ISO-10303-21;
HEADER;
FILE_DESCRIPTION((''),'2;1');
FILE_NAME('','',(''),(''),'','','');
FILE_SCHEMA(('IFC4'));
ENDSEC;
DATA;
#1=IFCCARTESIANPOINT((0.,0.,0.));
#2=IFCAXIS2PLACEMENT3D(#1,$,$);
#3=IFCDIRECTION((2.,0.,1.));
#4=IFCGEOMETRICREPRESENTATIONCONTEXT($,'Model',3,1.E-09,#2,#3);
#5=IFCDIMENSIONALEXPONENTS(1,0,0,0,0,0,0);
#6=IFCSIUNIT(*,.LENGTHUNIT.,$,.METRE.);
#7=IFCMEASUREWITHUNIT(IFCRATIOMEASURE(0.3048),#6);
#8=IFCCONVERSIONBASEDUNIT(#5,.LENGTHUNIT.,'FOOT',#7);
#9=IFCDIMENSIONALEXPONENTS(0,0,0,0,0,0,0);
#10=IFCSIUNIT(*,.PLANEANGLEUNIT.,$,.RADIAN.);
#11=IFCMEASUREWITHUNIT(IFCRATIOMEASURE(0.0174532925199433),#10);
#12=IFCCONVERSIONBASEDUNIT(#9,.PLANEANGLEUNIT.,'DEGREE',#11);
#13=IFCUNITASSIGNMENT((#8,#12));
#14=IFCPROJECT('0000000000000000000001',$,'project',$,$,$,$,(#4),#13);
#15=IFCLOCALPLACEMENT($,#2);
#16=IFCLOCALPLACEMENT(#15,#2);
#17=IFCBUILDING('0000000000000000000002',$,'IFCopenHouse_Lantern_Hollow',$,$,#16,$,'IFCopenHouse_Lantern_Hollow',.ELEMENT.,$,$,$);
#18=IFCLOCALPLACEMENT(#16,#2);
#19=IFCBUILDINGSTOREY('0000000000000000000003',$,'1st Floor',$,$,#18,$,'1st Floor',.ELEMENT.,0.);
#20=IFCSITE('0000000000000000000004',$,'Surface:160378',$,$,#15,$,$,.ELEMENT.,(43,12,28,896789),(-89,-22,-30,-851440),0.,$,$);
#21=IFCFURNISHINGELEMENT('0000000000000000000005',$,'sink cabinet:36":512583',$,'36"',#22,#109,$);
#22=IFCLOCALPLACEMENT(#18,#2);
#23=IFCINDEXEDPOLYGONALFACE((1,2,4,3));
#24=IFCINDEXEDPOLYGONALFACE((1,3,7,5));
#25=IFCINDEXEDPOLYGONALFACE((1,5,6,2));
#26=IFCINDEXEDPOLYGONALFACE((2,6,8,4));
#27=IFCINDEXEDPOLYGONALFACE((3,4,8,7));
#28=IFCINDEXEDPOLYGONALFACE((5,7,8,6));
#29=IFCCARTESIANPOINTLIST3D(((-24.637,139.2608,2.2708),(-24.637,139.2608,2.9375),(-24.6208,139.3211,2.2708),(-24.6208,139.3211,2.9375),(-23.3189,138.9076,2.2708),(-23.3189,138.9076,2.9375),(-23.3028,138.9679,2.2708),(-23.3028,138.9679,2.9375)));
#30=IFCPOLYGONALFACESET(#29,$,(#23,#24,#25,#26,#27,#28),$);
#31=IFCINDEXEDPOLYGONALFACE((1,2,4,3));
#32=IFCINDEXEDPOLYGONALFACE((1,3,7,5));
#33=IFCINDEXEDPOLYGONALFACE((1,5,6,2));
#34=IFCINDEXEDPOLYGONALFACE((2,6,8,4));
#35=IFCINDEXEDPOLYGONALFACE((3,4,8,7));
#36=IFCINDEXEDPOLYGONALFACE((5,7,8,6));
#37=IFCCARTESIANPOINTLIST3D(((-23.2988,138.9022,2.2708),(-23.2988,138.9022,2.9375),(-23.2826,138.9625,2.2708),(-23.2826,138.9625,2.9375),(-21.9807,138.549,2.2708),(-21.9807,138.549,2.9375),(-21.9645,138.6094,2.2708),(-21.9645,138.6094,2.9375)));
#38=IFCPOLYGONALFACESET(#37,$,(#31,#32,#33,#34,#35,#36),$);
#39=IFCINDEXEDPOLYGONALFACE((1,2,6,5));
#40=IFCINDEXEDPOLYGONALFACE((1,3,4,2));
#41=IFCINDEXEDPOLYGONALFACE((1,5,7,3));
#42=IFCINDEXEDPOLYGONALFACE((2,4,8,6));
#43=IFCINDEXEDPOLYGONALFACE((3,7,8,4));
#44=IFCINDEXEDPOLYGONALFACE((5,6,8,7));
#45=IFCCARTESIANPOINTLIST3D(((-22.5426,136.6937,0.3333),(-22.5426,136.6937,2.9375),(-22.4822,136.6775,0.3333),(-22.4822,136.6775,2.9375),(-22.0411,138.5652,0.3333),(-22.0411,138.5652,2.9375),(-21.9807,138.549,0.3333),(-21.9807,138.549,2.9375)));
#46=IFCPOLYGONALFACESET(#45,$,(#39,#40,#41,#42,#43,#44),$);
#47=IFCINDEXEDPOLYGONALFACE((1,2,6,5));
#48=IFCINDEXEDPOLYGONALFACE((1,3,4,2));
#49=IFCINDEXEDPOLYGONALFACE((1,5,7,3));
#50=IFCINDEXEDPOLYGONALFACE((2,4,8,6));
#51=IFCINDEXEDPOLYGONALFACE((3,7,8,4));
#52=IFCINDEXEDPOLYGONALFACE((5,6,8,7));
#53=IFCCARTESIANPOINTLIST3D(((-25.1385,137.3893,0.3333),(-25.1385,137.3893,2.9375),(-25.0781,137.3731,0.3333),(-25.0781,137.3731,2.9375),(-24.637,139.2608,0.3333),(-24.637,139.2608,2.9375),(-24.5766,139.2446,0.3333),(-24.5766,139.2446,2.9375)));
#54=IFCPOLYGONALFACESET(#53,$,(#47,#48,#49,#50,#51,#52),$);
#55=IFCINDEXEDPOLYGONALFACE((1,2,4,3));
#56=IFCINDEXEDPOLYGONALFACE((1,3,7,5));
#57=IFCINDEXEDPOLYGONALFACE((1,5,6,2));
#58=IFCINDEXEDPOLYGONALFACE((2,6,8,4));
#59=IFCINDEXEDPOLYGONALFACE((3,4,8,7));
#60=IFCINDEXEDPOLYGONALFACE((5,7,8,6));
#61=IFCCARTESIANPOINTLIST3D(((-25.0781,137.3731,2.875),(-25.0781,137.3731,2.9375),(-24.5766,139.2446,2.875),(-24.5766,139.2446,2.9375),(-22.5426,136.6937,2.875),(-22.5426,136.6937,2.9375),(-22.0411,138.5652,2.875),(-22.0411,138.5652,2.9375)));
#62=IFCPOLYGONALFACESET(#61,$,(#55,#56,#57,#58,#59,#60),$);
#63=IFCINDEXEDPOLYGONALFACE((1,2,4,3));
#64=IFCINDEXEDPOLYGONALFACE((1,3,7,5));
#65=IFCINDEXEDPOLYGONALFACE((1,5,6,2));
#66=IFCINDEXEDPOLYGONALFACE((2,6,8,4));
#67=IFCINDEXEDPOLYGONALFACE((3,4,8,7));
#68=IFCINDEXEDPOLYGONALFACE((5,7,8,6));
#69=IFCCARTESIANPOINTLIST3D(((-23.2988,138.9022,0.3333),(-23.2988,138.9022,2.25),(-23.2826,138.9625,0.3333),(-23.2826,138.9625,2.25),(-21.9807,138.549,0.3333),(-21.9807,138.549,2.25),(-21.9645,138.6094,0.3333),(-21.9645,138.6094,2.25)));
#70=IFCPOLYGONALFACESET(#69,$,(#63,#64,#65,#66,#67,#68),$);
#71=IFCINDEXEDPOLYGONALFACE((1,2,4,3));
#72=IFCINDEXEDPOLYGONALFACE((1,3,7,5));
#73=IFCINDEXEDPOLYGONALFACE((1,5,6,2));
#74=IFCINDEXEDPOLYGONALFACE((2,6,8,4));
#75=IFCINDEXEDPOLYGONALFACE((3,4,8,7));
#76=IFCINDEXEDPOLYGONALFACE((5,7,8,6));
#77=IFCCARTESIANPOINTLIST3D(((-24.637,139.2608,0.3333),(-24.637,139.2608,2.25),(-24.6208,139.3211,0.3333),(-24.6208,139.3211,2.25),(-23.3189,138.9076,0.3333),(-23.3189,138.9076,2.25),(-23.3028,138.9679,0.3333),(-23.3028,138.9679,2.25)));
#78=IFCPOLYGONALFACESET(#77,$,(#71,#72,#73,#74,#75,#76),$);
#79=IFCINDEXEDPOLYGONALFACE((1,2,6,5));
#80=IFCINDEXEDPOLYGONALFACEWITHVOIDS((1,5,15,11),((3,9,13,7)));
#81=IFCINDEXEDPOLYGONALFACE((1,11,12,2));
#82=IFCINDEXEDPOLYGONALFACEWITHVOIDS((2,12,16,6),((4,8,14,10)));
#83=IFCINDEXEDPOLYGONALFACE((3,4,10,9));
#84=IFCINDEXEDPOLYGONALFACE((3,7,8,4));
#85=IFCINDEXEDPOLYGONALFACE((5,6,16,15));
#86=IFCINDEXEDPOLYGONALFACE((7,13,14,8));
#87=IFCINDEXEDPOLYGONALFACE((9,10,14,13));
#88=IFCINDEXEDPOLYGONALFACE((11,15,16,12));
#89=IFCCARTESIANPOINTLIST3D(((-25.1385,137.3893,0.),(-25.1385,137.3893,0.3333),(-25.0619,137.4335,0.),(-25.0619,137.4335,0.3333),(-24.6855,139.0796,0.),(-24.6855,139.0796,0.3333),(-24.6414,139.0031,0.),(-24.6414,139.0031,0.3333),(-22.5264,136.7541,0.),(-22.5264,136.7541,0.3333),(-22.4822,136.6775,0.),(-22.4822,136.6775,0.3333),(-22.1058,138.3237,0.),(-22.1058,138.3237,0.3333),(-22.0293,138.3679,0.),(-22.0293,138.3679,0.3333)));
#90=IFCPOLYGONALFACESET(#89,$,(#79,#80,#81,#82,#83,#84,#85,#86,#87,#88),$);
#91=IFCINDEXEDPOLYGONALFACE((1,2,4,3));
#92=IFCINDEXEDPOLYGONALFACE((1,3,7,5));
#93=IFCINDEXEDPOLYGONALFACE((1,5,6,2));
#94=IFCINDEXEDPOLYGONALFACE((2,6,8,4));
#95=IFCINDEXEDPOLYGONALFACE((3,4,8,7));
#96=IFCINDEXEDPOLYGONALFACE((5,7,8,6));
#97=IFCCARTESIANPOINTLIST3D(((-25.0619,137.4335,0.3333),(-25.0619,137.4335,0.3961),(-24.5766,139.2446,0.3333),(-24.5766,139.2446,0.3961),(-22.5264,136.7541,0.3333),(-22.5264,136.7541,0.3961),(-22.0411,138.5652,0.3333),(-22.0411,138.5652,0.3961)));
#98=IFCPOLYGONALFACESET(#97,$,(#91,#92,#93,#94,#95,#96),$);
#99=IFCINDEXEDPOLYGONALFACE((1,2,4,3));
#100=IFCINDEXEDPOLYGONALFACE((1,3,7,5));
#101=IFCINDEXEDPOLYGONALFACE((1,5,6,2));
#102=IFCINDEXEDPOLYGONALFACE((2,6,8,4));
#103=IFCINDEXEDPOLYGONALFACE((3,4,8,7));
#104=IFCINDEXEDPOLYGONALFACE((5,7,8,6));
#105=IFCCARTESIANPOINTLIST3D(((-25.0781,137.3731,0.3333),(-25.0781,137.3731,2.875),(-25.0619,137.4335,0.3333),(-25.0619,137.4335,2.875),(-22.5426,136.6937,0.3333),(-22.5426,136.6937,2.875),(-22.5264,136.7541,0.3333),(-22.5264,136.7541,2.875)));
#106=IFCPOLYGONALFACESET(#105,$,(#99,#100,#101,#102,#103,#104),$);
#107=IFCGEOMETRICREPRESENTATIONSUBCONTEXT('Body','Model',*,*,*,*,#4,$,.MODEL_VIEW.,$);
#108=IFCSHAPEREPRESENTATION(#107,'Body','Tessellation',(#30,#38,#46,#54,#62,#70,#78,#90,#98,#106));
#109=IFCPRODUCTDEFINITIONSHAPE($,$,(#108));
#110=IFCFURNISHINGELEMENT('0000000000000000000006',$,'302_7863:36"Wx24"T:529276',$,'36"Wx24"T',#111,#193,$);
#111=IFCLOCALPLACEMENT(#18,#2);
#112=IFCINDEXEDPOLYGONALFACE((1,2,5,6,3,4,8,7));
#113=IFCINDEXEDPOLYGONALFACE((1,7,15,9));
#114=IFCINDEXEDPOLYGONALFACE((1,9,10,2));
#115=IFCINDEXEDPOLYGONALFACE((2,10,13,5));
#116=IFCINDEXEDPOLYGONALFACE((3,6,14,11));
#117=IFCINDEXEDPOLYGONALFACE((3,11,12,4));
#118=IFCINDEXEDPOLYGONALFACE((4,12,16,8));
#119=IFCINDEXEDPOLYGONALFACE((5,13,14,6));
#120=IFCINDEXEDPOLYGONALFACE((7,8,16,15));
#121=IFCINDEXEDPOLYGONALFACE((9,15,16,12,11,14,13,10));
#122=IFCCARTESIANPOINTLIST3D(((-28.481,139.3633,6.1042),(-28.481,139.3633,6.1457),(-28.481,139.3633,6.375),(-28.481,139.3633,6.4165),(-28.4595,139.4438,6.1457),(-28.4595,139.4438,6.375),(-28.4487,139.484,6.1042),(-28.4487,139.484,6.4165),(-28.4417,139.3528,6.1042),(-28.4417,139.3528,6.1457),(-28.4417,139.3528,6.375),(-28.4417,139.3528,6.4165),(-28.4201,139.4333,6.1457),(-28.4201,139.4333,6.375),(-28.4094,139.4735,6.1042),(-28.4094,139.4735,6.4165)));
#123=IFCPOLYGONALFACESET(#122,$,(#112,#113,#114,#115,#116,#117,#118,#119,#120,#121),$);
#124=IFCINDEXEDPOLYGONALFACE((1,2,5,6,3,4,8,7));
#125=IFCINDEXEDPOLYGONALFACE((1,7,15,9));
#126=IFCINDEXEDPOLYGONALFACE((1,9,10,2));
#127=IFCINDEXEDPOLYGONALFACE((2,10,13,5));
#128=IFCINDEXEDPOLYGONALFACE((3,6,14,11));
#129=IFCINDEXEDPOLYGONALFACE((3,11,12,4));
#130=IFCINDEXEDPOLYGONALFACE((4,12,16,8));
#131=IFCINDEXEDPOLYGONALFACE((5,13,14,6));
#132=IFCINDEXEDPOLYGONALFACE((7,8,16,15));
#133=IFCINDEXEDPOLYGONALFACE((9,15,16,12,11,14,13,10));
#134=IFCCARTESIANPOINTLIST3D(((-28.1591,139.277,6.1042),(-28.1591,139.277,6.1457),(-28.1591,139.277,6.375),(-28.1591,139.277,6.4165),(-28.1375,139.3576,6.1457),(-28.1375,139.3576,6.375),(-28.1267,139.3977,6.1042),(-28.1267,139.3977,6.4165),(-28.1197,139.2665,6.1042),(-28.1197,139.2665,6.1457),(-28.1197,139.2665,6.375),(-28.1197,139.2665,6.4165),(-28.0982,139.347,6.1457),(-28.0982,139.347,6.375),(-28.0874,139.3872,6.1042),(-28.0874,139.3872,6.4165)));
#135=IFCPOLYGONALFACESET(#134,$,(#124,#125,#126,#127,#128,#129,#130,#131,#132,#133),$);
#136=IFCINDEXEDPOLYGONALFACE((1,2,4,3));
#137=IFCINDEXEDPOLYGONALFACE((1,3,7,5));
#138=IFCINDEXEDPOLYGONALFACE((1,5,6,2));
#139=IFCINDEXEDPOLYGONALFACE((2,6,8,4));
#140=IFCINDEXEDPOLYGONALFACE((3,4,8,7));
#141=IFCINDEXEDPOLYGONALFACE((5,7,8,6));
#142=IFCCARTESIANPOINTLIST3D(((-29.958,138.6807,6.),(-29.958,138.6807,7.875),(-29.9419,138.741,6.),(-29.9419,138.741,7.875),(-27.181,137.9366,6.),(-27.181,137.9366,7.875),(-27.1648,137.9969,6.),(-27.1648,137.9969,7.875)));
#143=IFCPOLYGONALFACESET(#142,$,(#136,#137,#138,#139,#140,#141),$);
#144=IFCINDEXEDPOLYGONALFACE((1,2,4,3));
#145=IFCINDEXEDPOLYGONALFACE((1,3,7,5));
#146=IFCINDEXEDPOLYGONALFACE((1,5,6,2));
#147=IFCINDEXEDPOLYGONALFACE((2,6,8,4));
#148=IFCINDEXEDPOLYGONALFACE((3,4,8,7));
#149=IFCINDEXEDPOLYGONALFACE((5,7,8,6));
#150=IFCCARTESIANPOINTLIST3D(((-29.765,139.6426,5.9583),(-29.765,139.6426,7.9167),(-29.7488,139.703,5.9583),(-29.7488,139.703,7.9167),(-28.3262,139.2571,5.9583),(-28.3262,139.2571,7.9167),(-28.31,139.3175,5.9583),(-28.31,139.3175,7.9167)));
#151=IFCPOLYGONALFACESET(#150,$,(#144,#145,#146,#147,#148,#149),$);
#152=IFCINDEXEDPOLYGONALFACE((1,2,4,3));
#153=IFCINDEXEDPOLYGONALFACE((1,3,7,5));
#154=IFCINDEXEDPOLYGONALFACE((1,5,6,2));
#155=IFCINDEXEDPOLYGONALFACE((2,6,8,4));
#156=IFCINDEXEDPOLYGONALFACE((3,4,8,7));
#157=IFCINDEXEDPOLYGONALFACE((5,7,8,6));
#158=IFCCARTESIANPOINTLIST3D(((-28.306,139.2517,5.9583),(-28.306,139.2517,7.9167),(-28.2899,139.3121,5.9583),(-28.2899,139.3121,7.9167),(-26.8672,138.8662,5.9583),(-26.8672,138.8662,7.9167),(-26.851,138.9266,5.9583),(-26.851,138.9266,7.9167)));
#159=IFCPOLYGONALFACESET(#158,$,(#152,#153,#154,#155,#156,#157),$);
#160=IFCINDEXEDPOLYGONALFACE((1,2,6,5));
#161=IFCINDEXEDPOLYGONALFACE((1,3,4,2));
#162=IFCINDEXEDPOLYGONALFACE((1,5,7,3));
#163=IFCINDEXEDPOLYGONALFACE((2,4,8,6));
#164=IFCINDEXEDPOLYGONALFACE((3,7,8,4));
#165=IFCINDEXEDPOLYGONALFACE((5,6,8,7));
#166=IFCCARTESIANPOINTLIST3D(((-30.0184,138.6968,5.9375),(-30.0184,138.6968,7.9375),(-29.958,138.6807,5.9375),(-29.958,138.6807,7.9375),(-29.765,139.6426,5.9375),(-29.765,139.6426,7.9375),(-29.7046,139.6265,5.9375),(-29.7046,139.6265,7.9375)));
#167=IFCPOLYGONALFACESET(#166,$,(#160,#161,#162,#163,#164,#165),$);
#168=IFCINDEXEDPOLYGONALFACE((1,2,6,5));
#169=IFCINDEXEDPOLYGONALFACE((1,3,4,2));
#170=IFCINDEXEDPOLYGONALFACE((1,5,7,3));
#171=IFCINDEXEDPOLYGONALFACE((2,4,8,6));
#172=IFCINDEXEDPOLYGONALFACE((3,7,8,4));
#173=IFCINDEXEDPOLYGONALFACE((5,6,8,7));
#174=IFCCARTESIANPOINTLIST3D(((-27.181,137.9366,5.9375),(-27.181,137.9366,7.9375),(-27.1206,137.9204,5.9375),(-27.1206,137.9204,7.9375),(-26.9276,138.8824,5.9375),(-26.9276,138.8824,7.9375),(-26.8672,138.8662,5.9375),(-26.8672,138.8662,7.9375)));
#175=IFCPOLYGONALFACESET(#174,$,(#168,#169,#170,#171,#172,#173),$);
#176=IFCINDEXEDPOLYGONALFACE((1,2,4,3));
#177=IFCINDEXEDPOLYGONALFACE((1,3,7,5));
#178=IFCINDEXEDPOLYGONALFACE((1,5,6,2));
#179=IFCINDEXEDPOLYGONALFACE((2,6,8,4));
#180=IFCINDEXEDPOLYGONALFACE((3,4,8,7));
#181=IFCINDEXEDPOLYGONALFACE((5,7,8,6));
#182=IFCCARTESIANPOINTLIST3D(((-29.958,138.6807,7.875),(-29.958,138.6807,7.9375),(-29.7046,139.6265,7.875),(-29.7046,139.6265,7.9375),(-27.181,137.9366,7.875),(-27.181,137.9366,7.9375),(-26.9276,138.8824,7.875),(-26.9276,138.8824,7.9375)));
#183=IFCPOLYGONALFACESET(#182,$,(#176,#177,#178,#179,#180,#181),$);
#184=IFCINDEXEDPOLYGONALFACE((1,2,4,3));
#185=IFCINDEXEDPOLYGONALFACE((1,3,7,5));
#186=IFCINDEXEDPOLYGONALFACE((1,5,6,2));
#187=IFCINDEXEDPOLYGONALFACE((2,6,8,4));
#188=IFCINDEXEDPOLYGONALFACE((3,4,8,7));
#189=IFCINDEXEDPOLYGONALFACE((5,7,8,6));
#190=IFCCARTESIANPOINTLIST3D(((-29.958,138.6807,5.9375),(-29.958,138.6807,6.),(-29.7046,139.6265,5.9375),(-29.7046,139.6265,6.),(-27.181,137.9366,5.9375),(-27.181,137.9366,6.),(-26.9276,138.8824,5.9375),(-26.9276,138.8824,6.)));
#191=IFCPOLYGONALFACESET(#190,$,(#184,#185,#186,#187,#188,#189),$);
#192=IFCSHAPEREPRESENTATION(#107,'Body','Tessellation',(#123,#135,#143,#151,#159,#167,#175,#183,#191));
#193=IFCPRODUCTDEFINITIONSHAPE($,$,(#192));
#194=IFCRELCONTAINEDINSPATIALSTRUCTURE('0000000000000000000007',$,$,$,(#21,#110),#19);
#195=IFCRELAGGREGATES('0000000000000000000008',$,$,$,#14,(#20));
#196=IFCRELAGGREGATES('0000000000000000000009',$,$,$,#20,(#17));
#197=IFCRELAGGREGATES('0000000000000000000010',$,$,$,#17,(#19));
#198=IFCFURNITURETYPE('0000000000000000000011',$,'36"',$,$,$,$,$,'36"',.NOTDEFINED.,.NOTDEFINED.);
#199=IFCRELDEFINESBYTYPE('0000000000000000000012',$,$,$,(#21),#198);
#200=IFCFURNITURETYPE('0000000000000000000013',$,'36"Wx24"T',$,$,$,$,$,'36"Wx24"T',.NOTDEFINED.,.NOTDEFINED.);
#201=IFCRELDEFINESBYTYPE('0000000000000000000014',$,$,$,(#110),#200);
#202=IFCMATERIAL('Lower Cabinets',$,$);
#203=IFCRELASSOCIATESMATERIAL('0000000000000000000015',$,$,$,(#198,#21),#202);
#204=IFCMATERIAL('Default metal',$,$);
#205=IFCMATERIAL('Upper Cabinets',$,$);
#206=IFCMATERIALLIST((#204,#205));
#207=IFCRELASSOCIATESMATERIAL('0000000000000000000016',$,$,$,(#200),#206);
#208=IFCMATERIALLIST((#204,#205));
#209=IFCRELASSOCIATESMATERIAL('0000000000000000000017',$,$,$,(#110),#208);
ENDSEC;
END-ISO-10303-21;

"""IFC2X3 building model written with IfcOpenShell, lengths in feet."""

from ifc_helpers import new_model, entity, si_unit, converted_unit, direction, frame, frame_2d, origin, origin_2d_with_axis, place, context, subcontext, project, spatial, polyline, rectangle, outline, extrude, source, transform, mapped, material, material_list, type_object, type_shapes, element, save


model = new_model("IFC2X3")

# Units and contexts
model_context = context("Model", 3, precision=1e-09, world=origin(), true_north=direction((2.0, 0.0, 1.0)))
body_context = subcontext(model_context, "Body", "Model", "MODEL_VIEW")
ifc_project = project(units=[converted_unit("LENGTHUNIT", "FOOT", entity("IfcRatioMeasure", 0.3048), si_unit("LENGTHUNIT", "METRE"), dimensions=[1, 0, 0, 0, 0, 0, 0]), converted_unit("PLANEANGLEUNIT", "DEGREE", entity("IfcRatioMeasure", 0.0174532925199433), si_unit("PLANEANGLEUNIT", "RADIAN"), dimensions=[0, 0, 0, 0, 0, 0, 0])], contexts=[model_context])

# Site, building, storey
site_placement = place(None, origin())
site = spatial("IfcSite", under=ifc_project, at=site_placement, Name="Surface:160378", CompositionType="ELEMENT", RefLatitude=(43, 12, 28, 896789), RefLongitude=(-89, -22, -30, -851440), RefElevation=0.0)
building_placement = place(site_placement, origin())
building = spatial("IfcBuilding", under=site, at=building_placement, Name="IFCopenHouse_Lantern_Hollow", LongName="IFCopenHouse_Lantern_Hollow", CompositionType="ELEMENT")
storey_placement = place(building_placement, origin())
storey = spatial("IfcBuildingStorey", under=building, at=storey_placement, Name="1st Floor", LongName="1st Floor", CompositionType="ELEMENT", Elevation=0.0)

# Furnishing elements
ifc_material_1 = material(Name="Default metal")
ifc_material_2 = material(Name="Lower Cabinets")
furniture_type_1 = type_object("IfcFurnitureType", Name="36\"", ElementType="36\"", AssemblyPlace="NOTDEFINED", material=ifc_material_2)
shared_shape_1 = source(origin(), body_context, "Body", "SweptSolid", [
    extrude(rectangle(XDim=0.0625, YDim=1.3646, at=origin_2d_with_axis()), frame((0.7542, -1.9688, 2.2708), z_axis=(0.0, 0.0, 1.0), x_axis=(0.0, 1.0, 0.0)), (0.0, 0.0, 1.0), 0.6667),
    extrude(rectangle(XDim=0.0625, YDim=1.3646, at=origin_2d_with_axis()), frame((-0.6312, -1.9688, 2.2708), z_axis=(0.0, 0.0, 1.0), x_axis=(0.0, 1.0, 0.0)), (0.0, 0.0, 1.0), 0.6667),
    extrude(rectangle(XDim=0.0625, YDim=1.9375, at=frame_2d((0.0, 0.0), x_axis=(1.0, 0.0))), frame((-1.2823, -0.9687, 0.3333)), (0.0, 0.0, 1.0), 2.6042),
    extrude(rectangle(XDim=0.0625, YDim=1.9375, at=frame_2d((0.0, 0.0), x_axis=(1.0, 0.0))), frame((1.4052, -0.9687, 0.3333)), (0.0, 0.0, 1.0), 2.6042),
    extrude(rectangle(XDim=2.625, YDim=1.9375, at=origin_2d_with_axis()), frame((0.0615, -0.9688, 2.875), z_axis=(0.0, 0.0, 1.0), x_axis=(-1.0, 0.0, 0.0)), (0.0, 0.0, 1.0), 0.0625),
    extrude(rectangle(XDim=0.0625, YDim=1.3646, at=origin_2d_with_axis()), frame((-0.6312, -1.9688, 0.3333), z_axis=(0.0, 0.0, 1.0), x_axis=(0.0, 1.0, 0.0)), (0.0, 0.0, 1.0), 1.9167),
    extrude(rectangle(XDim=0.0625, YDim=1.3646, at=origin_2d_with_axis()), frame((0.7542, -1.9688, 0.3333), z_axis=(0.0, 0.0, 1.0), x_axis=(0.0, 1.0, 0.0)), (0.0, 0.0, 1.0), 1.9167),
    extrude(outline(polyline([(-1.375, -0.875), (1.375, -0.875), (1.375, 0.875), (-1.375, 0.875), (-1.375, -0.875)]), holes=[polyline([(-1.3125, -0.8125), (-1.3125, 0.8125), (1.3125, 0.8125), (1.3125, -0.8125), (-1.3125, -0.8125)])]), frame((0.0615, -0.875, 0.0)), (0.0, 0.0, 1.0), 0.3333),
    extrude(rectangle(XDim=2.625, YDim=1.875, at=frame_2d((0.0, 0.0), x_axis=(1.0, 0.0))), frame((0.0615, -1.0, 0.3333), z_axis=(0.0, 0.0, 1.0), x_axis=(-1.0, 0.0, 0.0)), (0.0, 0.0, 1.0), 0.0627),
    extrude(rectangle(XDim=0.0625, YDim=2.625, at=origin_2d_with_axis()), frame((0.0615, -0.0312, 0.3333), z_axis=(0.0, 0.0, 1.0), x_axis=(0.0, 1.0, 0.0)), (0.0, 0.0, 1.0), 2.5417),
])
type_shapes(furniture_type_1, [shared_shape_1])
furnishing_1_placement = place(storey_placement, frame((-23.751, 137.0175, 0.0), z_axis=(0.0, 0.0, 1.0), x_axis=(-0.965926, 0.258819, 0.0)))
element("IfcFurnishingElement", 1, at=furnishing_1_placement, inside=storey, type_object=furniture_type_1, material=ifc_material_2, Name="sink cabinet:36\":512583", ObjectType="36\"", context=body_context, shape_type="MappedRepresentation", body=[
    mapped(shared_shape_1, transform((0.0, 0.0, 0.0), scale=1.0)),
])
ifc_material_3 = material(Name="Upper Cabinets")
ifc_material_list_1 = material_list([ifc_material_1, ifc_material_3])
ifc_material_list_2 = material_list([ifc_material_1, ifc_material_3])
furniture_type_2 = type_object("IfcFurnitureType", Name="36\"Wx24\"T", ElementType="36\"Wx24\"T", AssemblyPlace="NOTDEFINED", material=ifc_material_list_2)
shared_shape_2 = source(origin(), body_context, "Body", "SweptSolid", [
    extrude(outline(polyline([(-0.0521, -0.1146), (-0.0521, -0.1562), (0.0729, -0.1562), (0.0729, 0.1562), (-0.0521, 0.1562), (-0.0521, 0.1146), (0.0313, 0.1146), (0.0313, -0.1146), (-0.0521, -0.1146)])), frame((1.3125, 1.0937, 0.3229), z_axis=(-1.0, 0.0, 0.0), x_axis=(0.0, 1.0, 0.0)), (0.0, 0.0, -1.0), 0.0407),
    extrude(outline(polyline([(-0.0521, -0.1146), (-0.0521, -0.1562), (0.0729, -0.1562), (0.0729, 0.1562), (-0.0521, 0.1562), (-0.0521, 0.1146), (0.0313, 0.1146), (0.0313, -0.1146), (-0.0521, -0.1146)])), frame((1.6458, 1.0937, 0.3229), z_axis=(-1.0, 0.0, 0.0), x_axis=(0.0, 1.0, 0.0)), (0.0, 0.0, -1.0), 0.0407),
    extrude(rectangle(XDim=0.0625, YDim=2.875, at=frame_2d((0.0, 0.0), x_axis=(1.0, 0.0))), frame((1.5, 0.0313, 0.0625), z_axis=(0.0, 0.0, 1.0), x_axis=(0.0, 1.0, 0.0)), (0.0, 0.0, 1.0), 1.875),
    extrude(rectangle(XDim=0.0625, YDim=1.4896, at=origin_2d_with_axis()), frame((0.7448, 1.0104, 0.0208), z_axis=(0.0, 0.0, 1.0), x_axis=(0.0, 1.0, 0.0)), (0.0, 0.0, 1.0), 1.9583),
    extrude(rectangle(XDim=0.0625, YDim=1.4896, at=frame_2d((0.0, 0.0), x_axis=(1.0, 0.0))), frame((2.2552, 1.0104, 0.0208), z_axis=(0.0, 0.0, 1.0), x_axis=(0.0, 1.0, 0.0)), (0.0, 0.0, 1.0), 1.9583),
    extrude(rectangle(XDim=0.0625, YDim=0.9792, at=frame_2d((0.0, 0.0), x_axis=(1.0, 0.0))), frame((0.0313, 0.4896, 0.0)), (0.0, 0.0, 1.0), 2.0),
    extrude(rectangle(XDim=0.0625, YDim=0.9792, at=frame_2d((0.0, 0.0), x_axis=(1.0, 0.0))), frame((2.9688, 0.4896, 0.0)), (0.0, 0.0, 1.0), 2.0),
    extrude(rectangle(XDim=2.875, YDim=0.9792, at=origin_2d_with_axis()), frame((1.5, 0.4896, 1.9375), z_axis=(0.0, 0.0, 1.0), x_axis=(-1.0, 0.0, 0.0)), (0.0, 0.0, 1.0), 0.0625),
    extrude(rectangle(XDim=2.875, YDim=0.9792, at=origin_2d_with_axis()), frame((1.5, 0.4896, 0.0), z_axis=(0.0, 0.0, 1.0), x_axis=(-1.0, 0.0, 0.0)), (0.0, 0.0, 1.0), 0.0625),
])
type_shapes(furniture_type_2, [shared_shape_2])
furnishing_2_placement = place(storey_placement, frame((-30.0184, 138.6968, 5.9375), z_axis=(0.0, 0.0, 1.0), x_axis=(0.965926, -0.258819, 0.0)))
element("IfcFurnishingElement", 2, at=furnishing_2_placement, inside=storey, type_object=furniture_type_2, material=ifc_material_list_1, Name="302_7863:36\"Wx24\"T:529276", ObjectType="36\"Wx24\"T", context=body_context, shape_type="MappedRepresentation", body=[
    mapped(shared_shape_2, transform((0.0, 0.0, 0.0), scale=1.0)),
])

save(model, "model.ifc")
